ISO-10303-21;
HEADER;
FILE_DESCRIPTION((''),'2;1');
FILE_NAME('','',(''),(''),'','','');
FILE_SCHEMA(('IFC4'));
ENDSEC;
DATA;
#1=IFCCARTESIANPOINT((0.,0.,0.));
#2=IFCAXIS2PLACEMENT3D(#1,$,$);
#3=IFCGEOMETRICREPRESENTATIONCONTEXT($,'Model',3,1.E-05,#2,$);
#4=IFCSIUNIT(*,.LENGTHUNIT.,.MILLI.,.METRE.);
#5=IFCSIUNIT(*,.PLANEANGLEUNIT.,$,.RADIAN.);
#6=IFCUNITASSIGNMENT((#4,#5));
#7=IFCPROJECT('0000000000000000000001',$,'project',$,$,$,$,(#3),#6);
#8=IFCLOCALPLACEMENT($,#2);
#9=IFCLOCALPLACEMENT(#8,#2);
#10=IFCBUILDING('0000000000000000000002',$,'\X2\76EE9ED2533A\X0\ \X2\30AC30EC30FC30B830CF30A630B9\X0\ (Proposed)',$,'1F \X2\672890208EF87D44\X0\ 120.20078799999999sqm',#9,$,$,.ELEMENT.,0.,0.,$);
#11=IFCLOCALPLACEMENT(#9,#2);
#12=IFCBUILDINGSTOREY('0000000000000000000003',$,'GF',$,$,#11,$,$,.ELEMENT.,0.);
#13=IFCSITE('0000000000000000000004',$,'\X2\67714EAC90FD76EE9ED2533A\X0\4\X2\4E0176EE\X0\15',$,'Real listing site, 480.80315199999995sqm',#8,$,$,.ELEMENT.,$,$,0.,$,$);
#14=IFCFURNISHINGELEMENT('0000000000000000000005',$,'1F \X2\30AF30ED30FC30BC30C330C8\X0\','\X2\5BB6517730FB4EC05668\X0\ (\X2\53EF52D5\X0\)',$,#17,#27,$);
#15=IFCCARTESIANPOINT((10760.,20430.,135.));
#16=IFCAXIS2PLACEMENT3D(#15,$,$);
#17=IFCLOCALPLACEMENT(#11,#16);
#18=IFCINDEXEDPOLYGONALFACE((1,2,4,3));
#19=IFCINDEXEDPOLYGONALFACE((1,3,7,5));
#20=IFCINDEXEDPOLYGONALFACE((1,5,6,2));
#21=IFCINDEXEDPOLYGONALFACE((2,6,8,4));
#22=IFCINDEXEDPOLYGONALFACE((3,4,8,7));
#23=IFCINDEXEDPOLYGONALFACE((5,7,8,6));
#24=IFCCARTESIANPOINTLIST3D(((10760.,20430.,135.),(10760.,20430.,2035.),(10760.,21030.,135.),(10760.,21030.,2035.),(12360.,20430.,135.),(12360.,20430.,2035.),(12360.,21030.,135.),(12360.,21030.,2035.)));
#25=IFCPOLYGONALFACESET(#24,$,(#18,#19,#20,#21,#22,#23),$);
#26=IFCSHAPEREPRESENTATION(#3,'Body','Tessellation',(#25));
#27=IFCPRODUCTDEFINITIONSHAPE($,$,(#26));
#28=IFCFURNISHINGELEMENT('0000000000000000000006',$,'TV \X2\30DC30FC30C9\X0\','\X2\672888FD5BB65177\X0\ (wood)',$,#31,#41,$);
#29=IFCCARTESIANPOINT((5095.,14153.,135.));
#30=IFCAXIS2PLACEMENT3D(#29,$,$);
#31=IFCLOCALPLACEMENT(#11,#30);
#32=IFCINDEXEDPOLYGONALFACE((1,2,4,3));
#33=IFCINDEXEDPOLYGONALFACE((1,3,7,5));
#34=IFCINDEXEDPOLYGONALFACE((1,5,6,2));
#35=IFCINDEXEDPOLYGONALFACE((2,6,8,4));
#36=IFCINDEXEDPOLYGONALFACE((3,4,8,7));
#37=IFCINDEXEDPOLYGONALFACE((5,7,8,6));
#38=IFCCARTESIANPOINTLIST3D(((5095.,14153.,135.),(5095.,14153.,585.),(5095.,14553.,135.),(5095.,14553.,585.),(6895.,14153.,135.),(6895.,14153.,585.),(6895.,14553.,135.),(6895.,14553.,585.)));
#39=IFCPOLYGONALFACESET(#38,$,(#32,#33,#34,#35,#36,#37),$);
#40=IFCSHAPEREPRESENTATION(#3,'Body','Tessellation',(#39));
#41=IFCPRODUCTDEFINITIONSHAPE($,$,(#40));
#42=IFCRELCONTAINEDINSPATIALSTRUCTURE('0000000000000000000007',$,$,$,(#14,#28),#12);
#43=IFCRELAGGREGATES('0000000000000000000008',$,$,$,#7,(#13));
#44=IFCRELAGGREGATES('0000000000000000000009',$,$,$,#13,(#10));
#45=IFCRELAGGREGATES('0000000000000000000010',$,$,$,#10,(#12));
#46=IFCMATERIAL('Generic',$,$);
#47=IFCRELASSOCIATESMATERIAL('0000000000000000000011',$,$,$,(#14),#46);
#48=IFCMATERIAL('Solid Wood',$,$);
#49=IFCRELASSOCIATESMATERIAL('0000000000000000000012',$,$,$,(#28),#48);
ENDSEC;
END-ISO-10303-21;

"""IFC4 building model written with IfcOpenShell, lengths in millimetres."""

from ifc_helpers import new_model, si_unit, frame, frame_2d, origin, place, context, project, spatial, rectangle, extrude, material, element, save


model = new_model("IFC4")

# Units and contexts
model_context = context("Model", 3, precision=1e-05, world=origin())
ifc_project = project(units=[si_unit("LENGTHUNIT", "METRE", prefix="MILLI"), si_unit("PLANEANGLEUNIT", "RADIAN")], contexts=[model_context])

# Site, building, storey
site_placement = place(None, origin())
site = spatial("IfcSite", under=ifc_project, at=site_placement, Name="東京都目黒区4丁目15", ObjectType="Real listing site, 480.80315199999995sqm", CompositionType="ELEMENT", RefElevation=0.0)
building_placement = place(site_placement, origin())
building = spatial("IfcBuilding", under=site, at=building_placement, Name="目黒区 ガレージハウス (Proposed)", ObjectType="1F 木造軸組 120.20078799999999sqm", CompositionType="ELEMENT", ElevationOfRefHeight=0.0, ElevationOfTerrain=0.0)
storey_placement = place(building_placement, origin())
storey = spatial("IfcBuildingStorey", under=building, at=storey_placement, Name="GF", CompositionType="ELEMENT", Elevation=0.0)

# Shared definitions
ifc_material_1 = material(Name="Solid Wood")

# Shared definitions
ifc_material_2 = material(Name="Generic")

# Furnishing elements
furnishing_1_placement = place(storey_placement, frame((10760.0, 20430.0, 135.0)))
element("IfcFurnishingElement", 1, at=furnishing_1_placement, inside=storey, material=ifc_material_2, Name="1F クローゼット", Description="家具・什器 (可動)", context=model_context, shape_type="SweptSolid", body=[
    extrude(rectangle(XDim=1600.0, YDim=600.0, at=frame_2d((800.0, 300.0))), frame((10760.0, 20430.0, 135.0)), (0.0, 0.0, 1.0), 1900.0),
])
furnishing_2_placement = place(storey_placement, frame((5095.0, 14153.0, 135.0)))
element("IfcFurnishingElement", 2, at=furnishing_2_placement, inside=storey, material=ifc_material_1, Name="TV ボード", Description="木製家具 (wood)", context=model_context, shape_type="SweptSolid", body=[
    extrude(rectangle(XDim=1800.0, YDim=400.0, at=frame_2d((900.0, 200.0))), frame((5095.0, 14153.0, 135.0)), (0.0, 0.0, 1.0), 450.0),
])

save(model, "model.ifc")
